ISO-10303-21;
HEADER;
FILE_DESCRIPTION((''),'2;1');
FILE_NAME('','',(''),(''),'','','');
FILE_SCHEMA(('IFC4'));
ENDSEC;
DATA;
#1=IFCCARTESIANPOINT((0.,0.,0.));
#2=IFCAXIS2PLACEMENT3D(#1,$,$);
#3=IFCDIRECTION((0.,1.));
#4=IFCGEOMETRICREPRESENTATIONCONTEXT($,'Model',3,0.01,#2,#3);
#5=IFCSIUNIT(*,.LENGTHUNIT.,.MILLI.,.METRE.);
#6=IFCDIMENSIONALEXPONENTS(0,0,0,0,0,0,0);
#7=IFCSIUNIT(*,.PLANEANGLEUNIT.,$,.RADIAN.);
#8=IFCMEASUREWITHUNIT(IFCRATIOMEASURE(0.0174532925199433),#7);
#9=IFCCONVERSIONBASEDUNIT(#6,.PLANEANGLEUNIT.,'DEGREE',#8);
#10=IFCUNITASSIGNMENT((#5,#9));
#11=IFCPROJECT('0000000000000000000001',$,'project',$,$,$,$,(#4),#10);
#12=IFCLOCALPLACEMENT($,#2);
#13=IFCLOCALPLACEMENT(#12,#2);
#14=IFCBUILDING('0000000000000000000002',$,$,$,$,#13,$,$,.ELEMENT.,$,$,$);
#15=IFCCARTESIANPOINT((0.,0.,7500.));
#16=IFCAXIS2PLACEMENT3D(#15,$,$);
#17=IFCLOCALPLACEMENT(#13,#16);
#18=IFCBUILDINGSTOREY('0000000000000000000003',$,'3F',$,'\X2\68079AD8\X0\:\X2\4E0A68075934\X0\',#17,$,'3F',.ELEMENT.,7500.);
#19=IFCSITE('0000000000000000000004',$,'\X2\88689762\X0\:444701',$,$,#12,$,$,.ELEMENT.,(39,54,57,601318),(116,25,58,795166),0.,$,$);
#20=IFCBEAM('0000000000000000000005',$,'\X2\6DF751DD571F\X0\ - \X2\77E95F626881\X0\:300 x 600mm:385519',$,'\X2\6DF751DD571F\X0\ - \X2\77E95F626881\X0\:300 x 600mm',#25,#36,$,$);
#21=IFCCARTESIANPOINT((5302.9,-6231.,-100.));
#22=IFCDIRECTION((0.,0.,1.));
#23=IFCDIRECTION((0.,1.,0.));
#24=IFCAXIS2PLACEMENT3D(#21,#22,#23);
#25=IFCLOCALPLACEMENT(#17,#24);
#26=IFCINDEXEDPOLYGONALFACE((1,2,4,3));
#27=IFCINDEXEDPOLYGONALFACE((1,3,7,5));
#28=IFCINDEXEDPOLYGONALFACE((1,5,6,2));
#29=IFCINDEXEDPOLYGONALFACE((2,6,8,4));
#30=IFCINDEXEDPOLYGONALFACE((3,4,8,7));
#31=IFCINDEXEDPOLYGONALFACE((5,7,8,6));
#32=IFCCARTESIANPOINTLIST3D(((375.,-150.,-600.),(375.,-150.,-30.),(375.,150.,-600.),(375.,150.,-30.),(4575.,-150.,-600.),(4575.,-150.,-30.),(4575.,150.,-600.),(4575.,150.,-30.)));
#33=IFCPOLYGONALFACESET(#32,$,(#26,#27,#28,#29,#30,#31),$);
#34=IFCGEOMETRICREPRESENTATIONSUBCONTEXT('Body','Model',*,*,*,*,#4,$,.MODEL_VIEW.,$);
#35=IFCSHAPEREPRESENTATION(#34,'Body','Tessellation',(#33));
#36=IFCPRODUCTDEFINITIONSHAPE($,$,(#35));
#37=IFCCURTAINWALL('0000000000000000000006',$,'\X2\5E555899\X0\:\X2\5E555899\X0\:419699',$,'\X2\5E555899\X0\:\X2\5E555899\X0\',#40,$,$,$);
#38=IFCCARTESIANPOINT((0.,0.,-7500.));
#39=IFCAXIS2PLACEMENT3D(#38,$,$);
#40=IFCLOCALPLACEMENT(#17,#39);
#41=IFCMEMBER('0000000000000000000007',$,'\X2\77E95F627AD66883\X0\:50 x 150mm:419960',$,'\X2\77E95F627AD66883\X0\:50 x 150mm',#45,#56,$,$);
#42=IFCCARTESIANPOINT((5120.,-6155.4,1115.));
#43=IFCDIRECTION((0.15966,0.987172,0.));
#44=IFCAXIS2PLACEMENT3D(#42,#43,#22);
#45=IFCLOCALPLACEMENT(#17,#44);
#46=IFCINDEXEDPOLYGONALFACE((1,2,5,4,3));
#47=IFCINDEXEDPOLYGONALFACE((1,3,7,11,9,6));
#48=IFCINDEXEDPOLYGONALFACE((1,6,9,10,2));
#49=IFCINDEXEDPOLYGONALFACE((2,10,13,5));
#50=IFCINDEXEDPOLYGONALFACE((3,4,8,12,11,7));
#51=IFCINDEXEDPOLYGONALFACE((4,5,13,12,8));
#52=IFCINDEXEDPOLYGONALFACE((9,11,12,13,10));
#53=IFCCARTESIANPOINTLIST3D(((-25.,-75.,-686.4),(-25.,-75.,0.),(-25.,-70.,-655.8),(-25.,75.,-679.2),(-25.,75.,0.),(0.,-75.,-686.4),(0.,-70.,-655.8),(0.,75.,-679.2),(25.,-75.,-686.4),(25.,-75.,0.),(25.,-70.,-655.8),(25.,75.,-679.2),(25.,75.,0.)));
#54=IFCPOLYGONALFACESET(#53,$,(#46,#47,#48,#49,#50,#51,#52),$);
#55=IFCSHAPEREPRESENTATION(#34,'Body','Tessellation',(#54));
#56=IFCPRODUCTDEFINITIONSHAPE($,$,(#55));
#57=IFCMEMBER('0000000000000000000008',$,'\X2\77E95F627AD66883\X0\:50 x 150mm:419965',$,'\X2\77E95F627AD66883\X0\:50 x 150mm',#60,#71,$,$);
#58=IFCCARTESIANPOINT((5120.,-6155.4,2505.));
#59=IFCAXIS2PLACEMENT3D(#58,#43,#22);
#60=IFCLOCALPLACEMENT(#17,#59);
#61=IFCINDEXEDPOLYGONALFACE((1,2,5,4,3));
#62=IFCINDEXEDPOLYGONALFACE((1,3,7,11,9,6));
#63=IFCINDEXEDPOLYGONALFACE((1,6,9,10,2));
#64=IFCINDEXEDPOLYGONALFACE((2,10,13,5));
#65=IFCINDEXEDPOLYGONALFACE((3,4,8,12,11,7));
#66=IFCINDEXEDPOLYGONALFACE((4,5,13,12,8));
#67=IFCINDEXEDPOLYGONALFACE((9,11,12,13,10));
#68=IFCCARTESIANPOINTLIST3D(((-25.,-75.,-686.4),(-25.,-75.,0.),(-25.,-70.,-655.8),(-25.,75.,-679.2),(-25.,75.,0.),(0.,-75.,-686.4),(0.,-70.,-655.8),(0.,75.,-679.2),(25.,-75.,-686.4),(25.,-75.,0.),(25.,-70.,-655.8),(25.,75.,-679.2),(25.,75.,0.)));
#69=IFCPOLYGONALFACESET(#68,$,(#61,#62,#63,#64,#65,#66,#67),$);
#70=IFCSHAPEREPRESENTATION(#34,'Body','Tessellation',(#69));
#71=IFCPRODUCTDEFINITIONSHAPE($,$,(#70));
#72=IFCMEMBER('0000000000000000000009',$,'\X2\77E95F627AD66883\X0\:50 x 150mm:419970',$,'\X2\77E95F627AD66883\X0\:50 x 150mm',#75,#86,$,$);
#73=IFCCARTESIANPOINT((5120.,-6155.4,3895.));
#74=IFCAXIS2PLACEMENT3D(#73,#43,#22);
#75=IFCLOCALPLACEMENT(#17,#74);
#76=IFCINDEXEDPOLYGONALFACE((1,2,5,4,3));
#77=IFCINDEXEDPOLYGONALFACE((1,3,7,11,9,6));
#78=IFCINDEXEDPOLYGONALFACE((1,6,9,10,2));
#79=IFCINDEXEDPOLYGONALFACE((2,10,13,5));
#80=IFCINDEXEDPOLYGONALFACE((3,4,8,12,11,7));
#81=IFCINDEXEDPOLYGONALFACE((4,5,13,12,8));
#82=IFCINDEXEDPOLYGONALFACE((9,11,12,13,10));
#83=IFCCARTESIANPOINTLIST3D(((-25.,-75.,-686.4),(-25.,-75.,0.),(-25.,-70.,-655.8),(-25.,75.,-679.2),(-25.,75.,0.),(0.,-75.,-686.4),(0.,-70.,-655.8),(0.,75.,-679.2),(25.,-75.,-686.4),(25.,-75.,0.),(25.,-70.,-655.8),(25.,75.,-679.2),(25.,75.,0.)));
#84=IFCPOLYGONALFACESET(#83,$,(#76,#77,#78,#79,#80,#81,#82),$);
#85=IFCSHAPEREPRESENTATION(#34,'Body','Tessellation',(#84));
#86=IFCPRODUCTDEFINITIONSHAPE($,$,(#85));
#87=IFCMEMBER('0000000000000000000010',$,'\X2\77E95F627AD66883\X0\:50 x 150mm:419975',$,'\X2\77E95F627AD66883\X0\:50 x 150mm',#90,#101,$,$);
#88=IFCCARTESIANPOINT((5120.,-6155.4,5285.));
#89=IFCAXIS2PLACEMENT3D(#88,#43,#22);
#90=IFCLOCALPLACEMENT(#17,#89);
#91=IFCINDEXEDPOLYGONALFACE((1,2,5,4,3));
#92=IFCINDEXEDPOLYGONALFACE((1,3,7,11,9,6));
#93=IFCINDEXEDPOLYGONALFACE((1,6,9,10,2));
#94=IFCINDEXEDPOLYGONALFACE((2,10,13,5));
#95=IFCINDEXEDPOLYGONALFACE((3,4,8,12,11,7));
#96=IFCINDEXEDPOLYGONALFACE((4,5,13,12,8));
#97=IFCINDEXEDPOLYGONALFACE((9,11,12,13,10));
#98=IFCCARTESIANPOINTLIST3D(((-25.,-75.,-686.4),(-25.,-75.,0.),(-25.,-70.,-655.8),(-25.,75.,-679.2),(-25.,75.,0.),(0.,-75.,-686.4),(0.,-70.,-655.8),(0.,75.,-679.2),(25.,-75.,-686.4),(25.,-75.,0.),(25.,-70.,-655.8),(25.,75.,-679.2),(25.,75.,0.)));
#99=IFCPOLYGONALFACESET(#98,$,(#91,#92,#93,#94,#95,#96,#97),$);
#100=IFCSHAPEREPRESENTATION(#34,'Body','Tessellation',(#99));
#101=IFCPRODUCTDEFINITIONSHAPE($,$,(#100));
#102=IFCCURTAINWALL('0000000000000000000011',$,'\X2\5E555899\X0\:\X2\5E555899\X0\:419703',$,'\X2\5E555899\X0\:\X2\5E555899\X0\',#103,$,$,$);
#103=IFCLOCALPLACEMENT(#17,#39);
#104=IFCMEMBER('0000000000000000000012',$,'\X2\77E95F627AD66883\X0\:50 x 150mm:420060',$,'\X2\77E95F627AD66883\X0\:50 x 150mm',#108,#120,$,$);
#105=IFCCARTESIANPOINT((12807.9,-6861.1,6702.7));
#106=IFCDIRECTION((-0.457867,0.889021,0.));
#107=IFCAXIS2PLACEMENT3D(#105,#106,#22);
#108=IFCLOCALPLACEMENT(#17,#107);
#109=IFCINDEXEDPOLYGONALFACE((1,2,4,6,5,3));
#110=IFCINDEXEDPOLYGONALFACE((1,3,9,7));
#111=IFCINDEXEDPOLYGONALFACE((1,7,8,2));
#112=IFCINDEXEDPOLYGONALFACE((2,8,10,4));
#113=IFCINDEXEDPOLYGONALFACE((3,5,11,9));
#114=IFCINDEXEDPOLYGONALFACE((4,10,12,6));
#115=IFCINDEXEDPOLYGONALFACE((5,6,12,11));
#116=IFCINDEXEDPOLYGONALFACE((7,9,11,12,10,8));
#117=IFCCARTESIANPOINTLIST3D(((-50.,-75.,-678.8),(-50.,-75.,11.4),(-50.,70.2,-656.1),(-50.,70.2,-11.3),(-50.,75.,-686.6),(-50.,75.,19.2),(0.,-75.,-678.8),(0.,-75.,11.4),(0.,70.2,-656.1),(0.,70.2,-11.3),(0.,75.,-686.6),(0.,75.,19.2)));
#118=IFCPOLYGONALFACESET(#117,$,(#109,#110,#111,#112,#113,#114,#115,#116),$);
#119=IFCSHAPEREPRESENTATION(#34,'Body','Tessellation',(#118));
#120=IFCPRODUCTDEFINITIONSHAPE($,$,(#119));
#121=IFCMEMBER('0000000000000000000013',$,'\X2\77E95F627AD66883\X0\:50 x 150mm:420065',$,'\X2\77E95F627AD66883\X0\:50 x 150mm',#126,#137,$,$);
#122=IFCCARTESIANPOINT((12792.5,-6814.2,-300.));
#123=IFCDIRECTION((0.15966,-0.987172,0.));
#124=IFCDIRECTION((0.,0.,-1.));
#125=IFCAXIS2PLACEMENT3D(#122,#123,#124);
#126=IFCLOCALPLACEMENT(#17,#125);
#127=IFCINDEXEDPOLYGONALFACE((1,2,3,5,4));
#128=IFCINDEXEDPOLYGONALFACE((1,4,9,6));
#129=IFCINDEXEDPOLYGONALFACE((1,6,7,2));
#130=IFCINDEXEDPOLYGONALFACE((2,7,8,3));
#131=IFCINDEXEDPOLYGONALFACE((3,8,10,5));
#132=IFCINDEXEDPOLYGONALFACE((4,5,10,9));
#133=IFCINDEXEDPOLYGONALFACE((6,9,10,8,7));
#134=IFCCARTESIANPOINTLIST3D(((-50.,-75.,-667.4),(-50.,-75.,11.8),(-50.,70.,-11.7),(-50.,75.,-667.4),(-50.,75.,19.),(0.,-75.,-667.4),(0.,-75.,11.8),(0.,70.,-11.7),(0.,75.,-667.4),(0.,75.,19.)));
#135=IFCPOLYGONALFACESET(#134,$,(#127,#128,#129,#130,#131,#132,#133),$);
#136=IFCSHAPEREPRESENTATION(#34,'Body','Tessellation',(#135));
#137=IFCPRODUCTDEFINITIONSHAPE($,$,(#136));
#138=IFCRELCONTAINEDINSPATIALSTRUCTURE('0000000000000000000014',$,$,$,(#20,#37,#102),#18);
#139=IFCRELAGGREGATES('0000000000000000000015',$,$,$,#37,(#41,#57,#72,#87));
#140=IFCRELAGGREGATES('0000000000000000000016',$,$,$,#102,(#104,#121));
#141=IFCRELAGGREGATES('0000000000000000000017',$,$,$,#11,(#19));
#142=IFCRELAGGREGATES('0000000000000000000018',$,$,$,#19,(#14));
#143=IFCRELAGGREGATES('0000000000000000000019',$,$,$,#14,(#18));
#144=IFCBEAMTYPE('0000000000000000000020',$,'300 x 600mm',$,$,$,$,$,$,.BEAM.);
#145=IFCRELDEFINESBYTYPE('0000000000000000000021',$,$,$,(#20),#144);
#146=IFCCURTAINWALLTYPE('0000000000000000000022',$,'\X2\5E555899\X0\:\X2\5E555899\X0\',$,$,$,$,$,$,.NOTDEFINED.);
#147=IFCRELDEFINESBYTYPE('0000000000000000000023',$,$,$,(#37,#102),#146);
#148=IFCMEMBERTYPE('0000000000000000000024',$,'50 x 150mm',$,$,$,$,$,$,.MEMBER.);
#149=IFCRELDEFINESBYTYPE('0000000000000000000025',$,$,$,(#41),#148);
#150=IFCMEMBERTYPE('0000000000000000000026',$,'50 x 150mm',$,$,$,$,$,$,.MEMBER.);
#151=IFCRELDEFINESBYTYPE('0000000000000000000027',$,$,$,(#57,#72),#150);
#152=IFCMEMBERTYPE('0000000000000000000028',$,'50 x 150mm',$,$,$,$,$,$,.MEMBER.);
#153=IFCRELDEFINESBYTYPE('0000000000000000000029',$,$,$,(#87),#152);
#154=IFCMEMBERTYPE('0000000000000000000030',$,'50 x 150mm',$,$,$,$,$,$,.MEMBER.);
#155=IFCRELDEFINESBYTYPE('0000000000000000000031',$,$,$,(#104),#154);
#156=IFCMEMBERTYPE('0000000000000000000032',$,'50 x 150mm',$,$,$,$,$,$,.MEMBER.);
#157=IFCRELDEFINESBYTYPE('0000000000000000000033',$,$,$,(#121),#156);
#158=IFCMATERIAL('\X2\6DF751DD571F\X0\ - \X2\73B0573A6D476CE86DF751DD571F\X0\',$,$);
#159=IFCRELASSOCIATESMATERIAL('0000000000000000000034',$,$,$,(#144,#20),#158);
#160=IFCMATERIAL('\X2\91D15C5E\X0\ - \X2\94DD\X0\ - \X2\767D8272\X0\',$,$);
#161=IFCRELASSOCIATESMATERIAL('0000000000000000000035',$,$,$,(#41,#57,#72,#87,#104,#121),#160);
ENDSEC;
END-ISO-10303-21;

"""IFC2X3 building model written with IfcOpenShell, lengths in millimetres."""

from ifc_helpers import new_model, entity, si_unit, converted_unit, direction, frame, frame_2d, origin, origin_2d_with_axis, place, context, subcontext, project, spatial, polyline, rectangle, extrude, clip, bounded_halfspace, source, transform, mapped, material, type_object, type_shapes, element, aggregate, save


model = new_model("IFC2X3")

# Units and contexts
model_context = context("Model", 3, precision=0.01, world=origin(), true_north=direction((0.0, 1.0)))
body_context = subcontext(model_context, "Body", "Model", "MODEL_VIEW")
ifc_project = project(units=[si_unit("LENGTHUNIT", "METRE", prefix="MILLI"), converted_unit("PLANEANGLEUNIT", "DEGREE", entity("IfcRatioMeasure", 0.0174532925199433), si_unit("PLANEANGLEUNIT", "RADIAN"), dimensions=[0, 0, 0, 0, 0, 0, 0])], contexts=[model_context])

# Site, building, storey
site_placement = place(None, origin())
site = spatial("IfcSite", under=ifc_project, at=site_placement, Name="表面:444701", CompositionType="ELEMENT", RefLatitude=(39, 54, 57, 601318), RefLongitude=(116, 25, 58, 795166), RefElevation=0.0)
building_placement = place(site_placement, origin())
building = spatial("IfcBuilding", under=site, at=building_placement, CompositionType="ELEMENT")
storey_placement = place(building_placement, frame((0.0, 0.0, 7500.0)))
storey = spatial("IfcBuildingStorey", under=building, at=storey_placement, Name="3F", ObjectType="标高:上标头", LongName="3F", CompositionType="ELEMENT", Elevation=7500.0)

# Beam
ifc_material_1 = material(Name="混凝土 - 现场浇注混凝土")
beam_type = type_object("IfcBeamType", Name="300 x 600mm", PredefinedType="BEAM", material=ifc_material_1)
beam_placement = place(storey_placement, frame((5302.9, -6231.0, -100.0), z_axis=(0.0, 0.0, 1.0), x_axis=(0.0, 1.0, 0.0)))
element("IfcBeam", 1, at=beam_placement, inside=storey, type_object=beam_type, material=ifc_material_1, Name="混凝土 - 矩形梁:300 x 600mm:385519", ObjectType="混凝土 - 矩形梁:300 x 600mm", context=body_context, shape_type="SweptSolid", body=[
    extrude(rectangle(XDim=570.0, YDim=300.0, at=frame_2d((0.0, 0.0), x_axis=(1.0, 0.0))), frame((375.0, 0.0, -315.0), z_axis=(1.0, 0.0, 0.0), x_axis=(0.0, 0.0, -1.0)), (0.0, 0.0, 1.0), 4200.0),
])

# Curtain wall, members
curtain_wall_type = type_object("IfcCurtainWallType", Name="幕墙:幕墙", PredefinedType="NOTDEFINED")
curtain_wall_1_placement = place(storey_placement, frame((0.0, 0.0, -7500.0)))
curtain_wall_1 = element("IfcCurtainWall", 2, at=curtain_wall_1_placement, inside=storey, type_object=curtain_wall_type, Name="幕墙:幕墙:419699", ObjectType="幕墙:幕墙")
ifc_material_2 = material(Name="金属 - 铝 - 白色")
member_type_1 = type_object("IfcMemberType", Name="50 x 150mm", PredefinedType="MEMBER")
shared_shape_1 = source(origin(), body_context, "Body", "Clipping", [
    clip(clip(clip(clip(extrude(rectangle(XDim=150.0, YDim=50.0, at=origin_2d_with_axis()), frame((0.0, 0.0, -686.4), z_axis=(0.0, 0.0, 1.0), x_axis=(0.0, -1.0, 0.0)), (0.0, 0.0, 1.0), 686.4), bounded_halfspace(frame((-1415.0, -70.0, -655.8), z_axis=(0.0, -0.15966, -0.987172), x_axis=(1.0, 0.0, 0.0)), False, frame((0.0, 0.0, -686.4), z_axis=(0.0, 0.0, 1.0), x_axis=(0.0, -1.0, 0.0)), polyline([(70.0, -25.0), (-75.0, -25.0), (-75.0, 0.0), (70.0, 0.0), (70.0, -25.0)]))), bounded_halfspace(frame((0.0, -70.0, -655.8), z_axis=(0.0, -0.15966, -0.987172), x_axis=(1.0, 0.0, 0.0)), False, frame((0.0, 0.0, -686.4), z_axis=(0.0, 0.0, 1.0), x_axis=(0.0, -1.0, 0.0)), polyline([(-75.0, 25.0), (70.0, 25.0), (70.0, 0.0), (-75.0, 0.0), (-75.0, 25.0)]))), bounded_halfspace(frame((-1415.0, -78.0, -705.1), z_axis=(0.0, 0.987172, -0.15966), x_axis=(1.0, 0.0, 0.0)), False, frame((0.0, 0.0, -686.4), z_axis=(0.0, 0.0, 1.0), x_axis=(0.0, -1.0, 0.0)), polyline([(75.0, 0.0), (75.0, -25.0), (70.0, -25.0), (70.0, 0.0), (75.0, 0.0)]))), bounded_halfspace(frame((0.0, -78.0, -705.1), z_axis=(0.0, 0.987172, -0.15966), x_axis=(1.0, 0.0, 0.0)), False, frame((0.0, 0.0, -686.4), z_axis=(0.0, 0.0, 1.0), x_axis=(0.0, -1.0, 0.0)), polyline([(70.0, 25.0), (75.0, 25.0), (75.0, 0.0), (70.0, 0.0), (70.0, 25.0)]))),
])
type_shapes(member_type_1, [shared_shape_1])
member_1_placement = place(storey_placement, frame((5120.0, -6155.4, 1115.0), z_axis=(0.15966, 0.987172, 0.0), x_axis=(0.0, 0.0, 1.0)))
member_1 = element("IfcMember", 3, at=member_1_placement, type_object=member_type_1, material=ifc_material_2, Name="矩形竖梃:50 x 150mm:419960", ObjectType="矩形竖梃:50 x 150mm", context=body_context, shape_type="MappedRepresentation", body=[
    mapped(shared_shape_1, transform((0.0, 0.0, 0.0), scale=1.0)),
])
member_type_2 = type_object("IfcMemberType", Name="50 x 150mm", PredefinedType="MEMBER")
shared_shape_2 = source(origin(), body_context, "Body", "Clipping", [
    clip(clip(clip(clip(extrude(rectangle(XDim=150.0, YDim=50.0, at=origin_2d_with_axis()), frame((0.0, 0.0, -686.4), z_axis=(0.0, 0.0, 1.0), x_axis=(0.0, -1.0, 0.0)), (0.0, 0.0, 1.0), 686.4), bounded_halfspace(frame((-1390.0, -70.0, -655.8), z_axis=(0.0, -0.15966, -0.987172), x_axis=(1.0, 0.0, 0.0)), False, frame((0.0, 0.0, -686.4), z_axis=(0.0, 0.0, 1.0), x_axis=(0.0, -1.0, 0.0)), polyline([(70.0, -25.0), (-75.0, -25.0), (-75.0, 0.0), (70.0, 0.0), (70.0, -25.0)]))), bounded_halfspace(frame((0.0, -70.0, -655.8), z_axis=(0.0, -0.15966, -0.987172), x_axis=(1.0, 0.0, 0.0)), False, frame((0.0, 0.0, -686.4), z_axis=(0.0, 0.0, 1.0), x_axis=(0.0, -1.0, 0.0)), polyline([(-75.0, 25.0), (70.0, 25.0), (70.0, 0.0), (-75.0, 0.0), (-75.0, 25.0)]))), bounded_halfspace(frame((-1390.0, -78.0, -705.1), z_axis=(0.0, 0.987172, -0.15966), x_axis=(1.0, 0.0, 0.0)), False, frame((0.0, 0.0, -686.4), z_axis=(0.0, 0.0, 1.0), x_axis=(0.0, -1.0, 0.0)), polyline([(75.0, 0.0), (75.0, -25.0), (70.0, -25.0), (70.0, 0.0), (75.0, 0.0)]))), bounded_halfspace(frame((0.0, -78.0, -705.1), z_axis=(0.0, 0.987172, -0.15966), x_axis=(1.0, 0.0, 0.0)), False, frame((0.0, 0.0, -686.4), z_axis=(0.0, 0.0, 1.0), x_axis=(0.0, -1.0, 0.0)), polyline([(70.0, 25.0), (75.0, 25.0), (75.0, 0.0), (70.0, 0.0), (70.0, 25.0)]))),
])
type_shapes(member_type_2, [shared_shape_2])
member_2_placement = place(storey_placement, frame((5120.0, -6155.4, 2505.0), z_axis=(0.15966, 0.987172, 0.0), x_axis=(0.0, 0.0, 1.0)))
member_2 = element("IfcMember", 4, at=member_2_placement, type_object=member_type_2, material=ifc_material_2, Name="矩形竖梃:50 x 150mm:419965", ObjectType="矩形竖梃:50 x 150mm", context=body_context, shape_type="MappedRepresentation", body=[
    mapped(shared_shape_2, transform((0.0, 0.0, 0.0), scale=1.0)),
])
member_3_placement = place(storey_placement, frame((5120.0, -6155.4, 3895.0), z_axis=(0.15966, 0.987172, 0.0), x_axis=(0.0, 0.0, 1.0)))
member_3 = element("IfcMember", 5, at=member_3_placement, type_object=member_type_2, material=ifc_material_2, Name="矩形竖梃:50 x 150mm:419970", ObjectType="矩形竖梃:50 x 150mm", context=body_context, shape_type="MappedRepresentation", body=[
    mapped(shared_shape_2, transform((0.0, 0.0, 0.0), scale=1.0)),
])
member_type_3 = type_object("IfcMemberType", Name="50 x 150mm", PredefinedType="MEMBER")
shared_shape_3 = source(origin(), body_context, "Body", "Clipping", [
    clip(clip(clip(clip(extrude(rectangle(XDim=150.0, YDim=50.0, at=frame_2d((0.0, 0.0), x_axis=(1.0, 0.0))), frame((0.0, 0.0, -686.4), z_axis=(0.0, 0.0, 1.0), x_axis=(0.0, -1.0, 0.0)), (0.0, 0.0, 1.0), 686.4), bounded_halfspace(frame((-1390.0, -70.0, -655.8), z_axis=(0.0, -0.15966, -0.987172), x_axis=(1.0, 0.0, 0.0)), False, frame((0.0, 0.0, -686.4), z_axis=(0.0, 0.0, 1.0), x_axis=(0.0, -1.0, 0.0)), polyline([(70.0, -25.0), (-75.0, -25.0), (-75.0, 0.0), (70.0, 0.0), (70.0, -25.0)]))), bounded_halfspace(frame((0.0, -70.0, -655.8), z_axis=(0.0, -0.15966, -0.987172), x_axis=(1.0, 0.0, 0.0)), False, frame((0.0, 0.0, -686.4), z_axis=(0.0, 0.0, 1.0), x_axis=(0.0, -1.0, 0.0)), polyline([(-75.0, 25.0), (70.0, 25.0), (70.0, 0.0), (-75.0, 0.0), (-75.0, 25.0)]))), bounded_halfspace(frame((-1390.0, -78.0, -705.1), z_axis=(0.0, 0.987172, -0.15966), x_axis=(1.0, 0.0, 0.0)), False, frame((0.0, 0.0, -686.4), z_axis=(0.0, 0.0, 1.0), x_axis=(0.0, -1.0, 0.0)), polyline([(75.0, 0.0), (75.0, -25.0), (70.0, -25.0), (70.0, 0.0), (75.0, 0.0)]))), bounded_halfspace(frame((0.0, -78.0, -705.1), z_axis=(0.0, 0.987172, -0.15966), x_axis=(1.0, 0.0, 0.0)), False, frame((0.0, 0.0, -686.4), z_axis=(0.0, 0.0, 1.0), x_axis=(0.0, -1.0, 0.0)), polyline([(70.0, 25.0), (75.0, 25.0), (75.0, 0.0), (70.0, 0.0), (70.0, 25.0)]))),
])
type_shapes(member_type_3, [shared_shape_3])
member_4_placement = place(storey_placement, frame((5120.0, -6155.4, 5285.0), z_axis=(0.15966, 0.987172, 0.0), x_axis=(0.0, 0.0, 1.0)))
member_4 = element("IfcMember", 6, at=member_4_placement, type_object=member_type_3, material=ifc_material_2, Name="矩形竖梃:50 x 150mm:419975", ObjectType="矩形竖梃:50 x 150mm", context=body_context, shape_type="MappedRepresentation", body=[
    mapped(shared_shape_3, transform((0.0, 0.0, 0.0), scale=1.0)),
])
aggregate(curtain_wall_1, [member_1, member_2, member_3, member_4])

# Curtain wall, members
curtain_wall_2_placement = place(storey_placement, frame((0.0, 0.0, -7500.0)))
curtain_wall_2 = element("IfcCurtainWall", 7, at=curtain_wall_2_placement, inside=storey, type_object=curtain_wall_type, Name="幕墙:幕墙:419703", ObjectType="幕墙:幕墙")
member_type_4 = type_object("IfcMemberType", Name="50 x 150mm", PredefinedType="MEMBER")
shared_shape_4 = source(origin(), body_context, "Body", "Clipping", [
    clip(clip(clip(clip(extrude(rectangle(XDim=50.0, YDim=150.0, at=origin_2d_with_axis()), frame((-25.0, 0.0, -686.6)), (0.0, 0.0, 1.0), 705.8), bounded_halfspace(frame((-1415.5, -78.0, -679.3), z_axis=(0.0, 0.154283, -0.988027), x_axis=(1.0, 0.0, 0.0)), False, frame((-25.0, 0.0, -686.6)), polyline([(25.0, 70.2), (25.0, -75.0), (-25.0, -75.0), (-25.0, 70.2), (25.0, 70.2)]))), bounded_halfspace(frame((-1415.5, 70.2, -656.1), z_axis=(0.0, -0.988027, -0.154283), x_axis=(1.0, 0.0, 0.0)), False, frame((-25.0, 0.0, -686.6)), polyline([(25.0, 75.0), (25.0, 70.2), (-25.0, 70.2), (-25.0, 75.0), (25.0, 75.0)]))), bounded_halfspace(frame((-1415.5, 78.0, 38.1), z_axis=(0.0, -0.988027, 0.154283), x_axis=(1.0, 0.0, 0.0)), False, frame((-25.0, 0.0, -686.6)), polyline([(25.0, 75.0), (-25.0, 75.0), (-25.0, 70.2), (25.0, 70.2), (25.0, 75.0)]))), bounded_halfspace(frame((-1415.5, 70.2, -11.3), z_axis=(0.0, 0.154283, 0.988027), x_axis=(1.0, 0.0, 0.0)), False, frame((-25.0, 0.0, -686.6)), polyline([(-25.0, 70.2), (-25.0, -75.0), (25.0, -75.0), (25.0, 70.2), (-25.0, 70.2)]))),
])
type_shapes(member_type_4, [shared_shape_4])
member_5_placement = place(storey_placement, frame((12807.9, -6861.1, 6702.7), z_axis=(-0.457867, 0.889021, 0.0), x_axis=(0.0, 0.0, 1.0)))
member_5 = element("IfcMember", 8, at=member_5_placement, type_object=member_type_4, material=ifc_material_2, Name="矩形竖梃:50 x 150mm:420060", ObjectType="矩形竖梃:50 x 150mm", context=body_context, shape_type="MappedRepresentation", body=[
    mapped(shared_shape_4, transform((0.0, 0.0, 0.0), scale=1.0)),
])
member_type_5 = type_object("IfcMemberType", Name="50 x 150mm", PredefinedType="MEMBER")
shared_shape_5 = source(origin(), body_context, "Body", "Clipping", [
    clip(clip(extrude(rectangle(XDim=50.0, YDim=150.0, at=frame_2d((0.0, 0.0), x_axis=(1.0, 0.0))), frame((-25.0, 0.0, -667.4)), (0.0, 0.0, 1.0), 686.4), bounded_halfspace(frame((0.0, 70.0, -11.7), z_axis=(0.0, -0.987172, 0.15966), x_axis=(-1.0, 0.0, 0.0)), False, frame((-25.0, 0.0, -667.4)), polyline([(25.0, 75.0), (-25.0, 75.0), (-25.0, 70.0), (25.0, 70.0), (25.0, 75.0)]))), bounded_halfspace(frame((0.0, -78.0, 12.3), z_axis=(0.0, 0.15966, 0.987172), x_axis=(-1.0, 0.0, 0.0)), False, frame((-25.0, 0.0, -667.4)), polyline([(-25.0, 70.0), (-25.0, -75.0), (25.0, -75.0), (25.0, 70.0), (-25.0, 70.0)]))),
])
type_shapes(member_type_5, [shared_shape_5])
member_6_placement = place(storey_placement, frame((12792.5, -6814.2, -300.0), z_axis=(0.15966, -0.987172, 0.0), x_axis=(0.0, 0.0, -1.0)))
member_6 = element("IfcMember", 9, at=member_6_placement, type_object=member_type_5, material=ifc_material_2, Name="矩形竖梃:50 x 150mm:420065", ObjectType="矩形竖梃:50 x 150mm", context=body_context, shape_type="MappedRepresentation", body=[
    mapped(shared_shape_5, transform((0.0, 0.0, 0.0), scale=1.0)),
])
aggregate(curtain_wall_2, [member_5, member_6])

save(model, "model.ifc")
